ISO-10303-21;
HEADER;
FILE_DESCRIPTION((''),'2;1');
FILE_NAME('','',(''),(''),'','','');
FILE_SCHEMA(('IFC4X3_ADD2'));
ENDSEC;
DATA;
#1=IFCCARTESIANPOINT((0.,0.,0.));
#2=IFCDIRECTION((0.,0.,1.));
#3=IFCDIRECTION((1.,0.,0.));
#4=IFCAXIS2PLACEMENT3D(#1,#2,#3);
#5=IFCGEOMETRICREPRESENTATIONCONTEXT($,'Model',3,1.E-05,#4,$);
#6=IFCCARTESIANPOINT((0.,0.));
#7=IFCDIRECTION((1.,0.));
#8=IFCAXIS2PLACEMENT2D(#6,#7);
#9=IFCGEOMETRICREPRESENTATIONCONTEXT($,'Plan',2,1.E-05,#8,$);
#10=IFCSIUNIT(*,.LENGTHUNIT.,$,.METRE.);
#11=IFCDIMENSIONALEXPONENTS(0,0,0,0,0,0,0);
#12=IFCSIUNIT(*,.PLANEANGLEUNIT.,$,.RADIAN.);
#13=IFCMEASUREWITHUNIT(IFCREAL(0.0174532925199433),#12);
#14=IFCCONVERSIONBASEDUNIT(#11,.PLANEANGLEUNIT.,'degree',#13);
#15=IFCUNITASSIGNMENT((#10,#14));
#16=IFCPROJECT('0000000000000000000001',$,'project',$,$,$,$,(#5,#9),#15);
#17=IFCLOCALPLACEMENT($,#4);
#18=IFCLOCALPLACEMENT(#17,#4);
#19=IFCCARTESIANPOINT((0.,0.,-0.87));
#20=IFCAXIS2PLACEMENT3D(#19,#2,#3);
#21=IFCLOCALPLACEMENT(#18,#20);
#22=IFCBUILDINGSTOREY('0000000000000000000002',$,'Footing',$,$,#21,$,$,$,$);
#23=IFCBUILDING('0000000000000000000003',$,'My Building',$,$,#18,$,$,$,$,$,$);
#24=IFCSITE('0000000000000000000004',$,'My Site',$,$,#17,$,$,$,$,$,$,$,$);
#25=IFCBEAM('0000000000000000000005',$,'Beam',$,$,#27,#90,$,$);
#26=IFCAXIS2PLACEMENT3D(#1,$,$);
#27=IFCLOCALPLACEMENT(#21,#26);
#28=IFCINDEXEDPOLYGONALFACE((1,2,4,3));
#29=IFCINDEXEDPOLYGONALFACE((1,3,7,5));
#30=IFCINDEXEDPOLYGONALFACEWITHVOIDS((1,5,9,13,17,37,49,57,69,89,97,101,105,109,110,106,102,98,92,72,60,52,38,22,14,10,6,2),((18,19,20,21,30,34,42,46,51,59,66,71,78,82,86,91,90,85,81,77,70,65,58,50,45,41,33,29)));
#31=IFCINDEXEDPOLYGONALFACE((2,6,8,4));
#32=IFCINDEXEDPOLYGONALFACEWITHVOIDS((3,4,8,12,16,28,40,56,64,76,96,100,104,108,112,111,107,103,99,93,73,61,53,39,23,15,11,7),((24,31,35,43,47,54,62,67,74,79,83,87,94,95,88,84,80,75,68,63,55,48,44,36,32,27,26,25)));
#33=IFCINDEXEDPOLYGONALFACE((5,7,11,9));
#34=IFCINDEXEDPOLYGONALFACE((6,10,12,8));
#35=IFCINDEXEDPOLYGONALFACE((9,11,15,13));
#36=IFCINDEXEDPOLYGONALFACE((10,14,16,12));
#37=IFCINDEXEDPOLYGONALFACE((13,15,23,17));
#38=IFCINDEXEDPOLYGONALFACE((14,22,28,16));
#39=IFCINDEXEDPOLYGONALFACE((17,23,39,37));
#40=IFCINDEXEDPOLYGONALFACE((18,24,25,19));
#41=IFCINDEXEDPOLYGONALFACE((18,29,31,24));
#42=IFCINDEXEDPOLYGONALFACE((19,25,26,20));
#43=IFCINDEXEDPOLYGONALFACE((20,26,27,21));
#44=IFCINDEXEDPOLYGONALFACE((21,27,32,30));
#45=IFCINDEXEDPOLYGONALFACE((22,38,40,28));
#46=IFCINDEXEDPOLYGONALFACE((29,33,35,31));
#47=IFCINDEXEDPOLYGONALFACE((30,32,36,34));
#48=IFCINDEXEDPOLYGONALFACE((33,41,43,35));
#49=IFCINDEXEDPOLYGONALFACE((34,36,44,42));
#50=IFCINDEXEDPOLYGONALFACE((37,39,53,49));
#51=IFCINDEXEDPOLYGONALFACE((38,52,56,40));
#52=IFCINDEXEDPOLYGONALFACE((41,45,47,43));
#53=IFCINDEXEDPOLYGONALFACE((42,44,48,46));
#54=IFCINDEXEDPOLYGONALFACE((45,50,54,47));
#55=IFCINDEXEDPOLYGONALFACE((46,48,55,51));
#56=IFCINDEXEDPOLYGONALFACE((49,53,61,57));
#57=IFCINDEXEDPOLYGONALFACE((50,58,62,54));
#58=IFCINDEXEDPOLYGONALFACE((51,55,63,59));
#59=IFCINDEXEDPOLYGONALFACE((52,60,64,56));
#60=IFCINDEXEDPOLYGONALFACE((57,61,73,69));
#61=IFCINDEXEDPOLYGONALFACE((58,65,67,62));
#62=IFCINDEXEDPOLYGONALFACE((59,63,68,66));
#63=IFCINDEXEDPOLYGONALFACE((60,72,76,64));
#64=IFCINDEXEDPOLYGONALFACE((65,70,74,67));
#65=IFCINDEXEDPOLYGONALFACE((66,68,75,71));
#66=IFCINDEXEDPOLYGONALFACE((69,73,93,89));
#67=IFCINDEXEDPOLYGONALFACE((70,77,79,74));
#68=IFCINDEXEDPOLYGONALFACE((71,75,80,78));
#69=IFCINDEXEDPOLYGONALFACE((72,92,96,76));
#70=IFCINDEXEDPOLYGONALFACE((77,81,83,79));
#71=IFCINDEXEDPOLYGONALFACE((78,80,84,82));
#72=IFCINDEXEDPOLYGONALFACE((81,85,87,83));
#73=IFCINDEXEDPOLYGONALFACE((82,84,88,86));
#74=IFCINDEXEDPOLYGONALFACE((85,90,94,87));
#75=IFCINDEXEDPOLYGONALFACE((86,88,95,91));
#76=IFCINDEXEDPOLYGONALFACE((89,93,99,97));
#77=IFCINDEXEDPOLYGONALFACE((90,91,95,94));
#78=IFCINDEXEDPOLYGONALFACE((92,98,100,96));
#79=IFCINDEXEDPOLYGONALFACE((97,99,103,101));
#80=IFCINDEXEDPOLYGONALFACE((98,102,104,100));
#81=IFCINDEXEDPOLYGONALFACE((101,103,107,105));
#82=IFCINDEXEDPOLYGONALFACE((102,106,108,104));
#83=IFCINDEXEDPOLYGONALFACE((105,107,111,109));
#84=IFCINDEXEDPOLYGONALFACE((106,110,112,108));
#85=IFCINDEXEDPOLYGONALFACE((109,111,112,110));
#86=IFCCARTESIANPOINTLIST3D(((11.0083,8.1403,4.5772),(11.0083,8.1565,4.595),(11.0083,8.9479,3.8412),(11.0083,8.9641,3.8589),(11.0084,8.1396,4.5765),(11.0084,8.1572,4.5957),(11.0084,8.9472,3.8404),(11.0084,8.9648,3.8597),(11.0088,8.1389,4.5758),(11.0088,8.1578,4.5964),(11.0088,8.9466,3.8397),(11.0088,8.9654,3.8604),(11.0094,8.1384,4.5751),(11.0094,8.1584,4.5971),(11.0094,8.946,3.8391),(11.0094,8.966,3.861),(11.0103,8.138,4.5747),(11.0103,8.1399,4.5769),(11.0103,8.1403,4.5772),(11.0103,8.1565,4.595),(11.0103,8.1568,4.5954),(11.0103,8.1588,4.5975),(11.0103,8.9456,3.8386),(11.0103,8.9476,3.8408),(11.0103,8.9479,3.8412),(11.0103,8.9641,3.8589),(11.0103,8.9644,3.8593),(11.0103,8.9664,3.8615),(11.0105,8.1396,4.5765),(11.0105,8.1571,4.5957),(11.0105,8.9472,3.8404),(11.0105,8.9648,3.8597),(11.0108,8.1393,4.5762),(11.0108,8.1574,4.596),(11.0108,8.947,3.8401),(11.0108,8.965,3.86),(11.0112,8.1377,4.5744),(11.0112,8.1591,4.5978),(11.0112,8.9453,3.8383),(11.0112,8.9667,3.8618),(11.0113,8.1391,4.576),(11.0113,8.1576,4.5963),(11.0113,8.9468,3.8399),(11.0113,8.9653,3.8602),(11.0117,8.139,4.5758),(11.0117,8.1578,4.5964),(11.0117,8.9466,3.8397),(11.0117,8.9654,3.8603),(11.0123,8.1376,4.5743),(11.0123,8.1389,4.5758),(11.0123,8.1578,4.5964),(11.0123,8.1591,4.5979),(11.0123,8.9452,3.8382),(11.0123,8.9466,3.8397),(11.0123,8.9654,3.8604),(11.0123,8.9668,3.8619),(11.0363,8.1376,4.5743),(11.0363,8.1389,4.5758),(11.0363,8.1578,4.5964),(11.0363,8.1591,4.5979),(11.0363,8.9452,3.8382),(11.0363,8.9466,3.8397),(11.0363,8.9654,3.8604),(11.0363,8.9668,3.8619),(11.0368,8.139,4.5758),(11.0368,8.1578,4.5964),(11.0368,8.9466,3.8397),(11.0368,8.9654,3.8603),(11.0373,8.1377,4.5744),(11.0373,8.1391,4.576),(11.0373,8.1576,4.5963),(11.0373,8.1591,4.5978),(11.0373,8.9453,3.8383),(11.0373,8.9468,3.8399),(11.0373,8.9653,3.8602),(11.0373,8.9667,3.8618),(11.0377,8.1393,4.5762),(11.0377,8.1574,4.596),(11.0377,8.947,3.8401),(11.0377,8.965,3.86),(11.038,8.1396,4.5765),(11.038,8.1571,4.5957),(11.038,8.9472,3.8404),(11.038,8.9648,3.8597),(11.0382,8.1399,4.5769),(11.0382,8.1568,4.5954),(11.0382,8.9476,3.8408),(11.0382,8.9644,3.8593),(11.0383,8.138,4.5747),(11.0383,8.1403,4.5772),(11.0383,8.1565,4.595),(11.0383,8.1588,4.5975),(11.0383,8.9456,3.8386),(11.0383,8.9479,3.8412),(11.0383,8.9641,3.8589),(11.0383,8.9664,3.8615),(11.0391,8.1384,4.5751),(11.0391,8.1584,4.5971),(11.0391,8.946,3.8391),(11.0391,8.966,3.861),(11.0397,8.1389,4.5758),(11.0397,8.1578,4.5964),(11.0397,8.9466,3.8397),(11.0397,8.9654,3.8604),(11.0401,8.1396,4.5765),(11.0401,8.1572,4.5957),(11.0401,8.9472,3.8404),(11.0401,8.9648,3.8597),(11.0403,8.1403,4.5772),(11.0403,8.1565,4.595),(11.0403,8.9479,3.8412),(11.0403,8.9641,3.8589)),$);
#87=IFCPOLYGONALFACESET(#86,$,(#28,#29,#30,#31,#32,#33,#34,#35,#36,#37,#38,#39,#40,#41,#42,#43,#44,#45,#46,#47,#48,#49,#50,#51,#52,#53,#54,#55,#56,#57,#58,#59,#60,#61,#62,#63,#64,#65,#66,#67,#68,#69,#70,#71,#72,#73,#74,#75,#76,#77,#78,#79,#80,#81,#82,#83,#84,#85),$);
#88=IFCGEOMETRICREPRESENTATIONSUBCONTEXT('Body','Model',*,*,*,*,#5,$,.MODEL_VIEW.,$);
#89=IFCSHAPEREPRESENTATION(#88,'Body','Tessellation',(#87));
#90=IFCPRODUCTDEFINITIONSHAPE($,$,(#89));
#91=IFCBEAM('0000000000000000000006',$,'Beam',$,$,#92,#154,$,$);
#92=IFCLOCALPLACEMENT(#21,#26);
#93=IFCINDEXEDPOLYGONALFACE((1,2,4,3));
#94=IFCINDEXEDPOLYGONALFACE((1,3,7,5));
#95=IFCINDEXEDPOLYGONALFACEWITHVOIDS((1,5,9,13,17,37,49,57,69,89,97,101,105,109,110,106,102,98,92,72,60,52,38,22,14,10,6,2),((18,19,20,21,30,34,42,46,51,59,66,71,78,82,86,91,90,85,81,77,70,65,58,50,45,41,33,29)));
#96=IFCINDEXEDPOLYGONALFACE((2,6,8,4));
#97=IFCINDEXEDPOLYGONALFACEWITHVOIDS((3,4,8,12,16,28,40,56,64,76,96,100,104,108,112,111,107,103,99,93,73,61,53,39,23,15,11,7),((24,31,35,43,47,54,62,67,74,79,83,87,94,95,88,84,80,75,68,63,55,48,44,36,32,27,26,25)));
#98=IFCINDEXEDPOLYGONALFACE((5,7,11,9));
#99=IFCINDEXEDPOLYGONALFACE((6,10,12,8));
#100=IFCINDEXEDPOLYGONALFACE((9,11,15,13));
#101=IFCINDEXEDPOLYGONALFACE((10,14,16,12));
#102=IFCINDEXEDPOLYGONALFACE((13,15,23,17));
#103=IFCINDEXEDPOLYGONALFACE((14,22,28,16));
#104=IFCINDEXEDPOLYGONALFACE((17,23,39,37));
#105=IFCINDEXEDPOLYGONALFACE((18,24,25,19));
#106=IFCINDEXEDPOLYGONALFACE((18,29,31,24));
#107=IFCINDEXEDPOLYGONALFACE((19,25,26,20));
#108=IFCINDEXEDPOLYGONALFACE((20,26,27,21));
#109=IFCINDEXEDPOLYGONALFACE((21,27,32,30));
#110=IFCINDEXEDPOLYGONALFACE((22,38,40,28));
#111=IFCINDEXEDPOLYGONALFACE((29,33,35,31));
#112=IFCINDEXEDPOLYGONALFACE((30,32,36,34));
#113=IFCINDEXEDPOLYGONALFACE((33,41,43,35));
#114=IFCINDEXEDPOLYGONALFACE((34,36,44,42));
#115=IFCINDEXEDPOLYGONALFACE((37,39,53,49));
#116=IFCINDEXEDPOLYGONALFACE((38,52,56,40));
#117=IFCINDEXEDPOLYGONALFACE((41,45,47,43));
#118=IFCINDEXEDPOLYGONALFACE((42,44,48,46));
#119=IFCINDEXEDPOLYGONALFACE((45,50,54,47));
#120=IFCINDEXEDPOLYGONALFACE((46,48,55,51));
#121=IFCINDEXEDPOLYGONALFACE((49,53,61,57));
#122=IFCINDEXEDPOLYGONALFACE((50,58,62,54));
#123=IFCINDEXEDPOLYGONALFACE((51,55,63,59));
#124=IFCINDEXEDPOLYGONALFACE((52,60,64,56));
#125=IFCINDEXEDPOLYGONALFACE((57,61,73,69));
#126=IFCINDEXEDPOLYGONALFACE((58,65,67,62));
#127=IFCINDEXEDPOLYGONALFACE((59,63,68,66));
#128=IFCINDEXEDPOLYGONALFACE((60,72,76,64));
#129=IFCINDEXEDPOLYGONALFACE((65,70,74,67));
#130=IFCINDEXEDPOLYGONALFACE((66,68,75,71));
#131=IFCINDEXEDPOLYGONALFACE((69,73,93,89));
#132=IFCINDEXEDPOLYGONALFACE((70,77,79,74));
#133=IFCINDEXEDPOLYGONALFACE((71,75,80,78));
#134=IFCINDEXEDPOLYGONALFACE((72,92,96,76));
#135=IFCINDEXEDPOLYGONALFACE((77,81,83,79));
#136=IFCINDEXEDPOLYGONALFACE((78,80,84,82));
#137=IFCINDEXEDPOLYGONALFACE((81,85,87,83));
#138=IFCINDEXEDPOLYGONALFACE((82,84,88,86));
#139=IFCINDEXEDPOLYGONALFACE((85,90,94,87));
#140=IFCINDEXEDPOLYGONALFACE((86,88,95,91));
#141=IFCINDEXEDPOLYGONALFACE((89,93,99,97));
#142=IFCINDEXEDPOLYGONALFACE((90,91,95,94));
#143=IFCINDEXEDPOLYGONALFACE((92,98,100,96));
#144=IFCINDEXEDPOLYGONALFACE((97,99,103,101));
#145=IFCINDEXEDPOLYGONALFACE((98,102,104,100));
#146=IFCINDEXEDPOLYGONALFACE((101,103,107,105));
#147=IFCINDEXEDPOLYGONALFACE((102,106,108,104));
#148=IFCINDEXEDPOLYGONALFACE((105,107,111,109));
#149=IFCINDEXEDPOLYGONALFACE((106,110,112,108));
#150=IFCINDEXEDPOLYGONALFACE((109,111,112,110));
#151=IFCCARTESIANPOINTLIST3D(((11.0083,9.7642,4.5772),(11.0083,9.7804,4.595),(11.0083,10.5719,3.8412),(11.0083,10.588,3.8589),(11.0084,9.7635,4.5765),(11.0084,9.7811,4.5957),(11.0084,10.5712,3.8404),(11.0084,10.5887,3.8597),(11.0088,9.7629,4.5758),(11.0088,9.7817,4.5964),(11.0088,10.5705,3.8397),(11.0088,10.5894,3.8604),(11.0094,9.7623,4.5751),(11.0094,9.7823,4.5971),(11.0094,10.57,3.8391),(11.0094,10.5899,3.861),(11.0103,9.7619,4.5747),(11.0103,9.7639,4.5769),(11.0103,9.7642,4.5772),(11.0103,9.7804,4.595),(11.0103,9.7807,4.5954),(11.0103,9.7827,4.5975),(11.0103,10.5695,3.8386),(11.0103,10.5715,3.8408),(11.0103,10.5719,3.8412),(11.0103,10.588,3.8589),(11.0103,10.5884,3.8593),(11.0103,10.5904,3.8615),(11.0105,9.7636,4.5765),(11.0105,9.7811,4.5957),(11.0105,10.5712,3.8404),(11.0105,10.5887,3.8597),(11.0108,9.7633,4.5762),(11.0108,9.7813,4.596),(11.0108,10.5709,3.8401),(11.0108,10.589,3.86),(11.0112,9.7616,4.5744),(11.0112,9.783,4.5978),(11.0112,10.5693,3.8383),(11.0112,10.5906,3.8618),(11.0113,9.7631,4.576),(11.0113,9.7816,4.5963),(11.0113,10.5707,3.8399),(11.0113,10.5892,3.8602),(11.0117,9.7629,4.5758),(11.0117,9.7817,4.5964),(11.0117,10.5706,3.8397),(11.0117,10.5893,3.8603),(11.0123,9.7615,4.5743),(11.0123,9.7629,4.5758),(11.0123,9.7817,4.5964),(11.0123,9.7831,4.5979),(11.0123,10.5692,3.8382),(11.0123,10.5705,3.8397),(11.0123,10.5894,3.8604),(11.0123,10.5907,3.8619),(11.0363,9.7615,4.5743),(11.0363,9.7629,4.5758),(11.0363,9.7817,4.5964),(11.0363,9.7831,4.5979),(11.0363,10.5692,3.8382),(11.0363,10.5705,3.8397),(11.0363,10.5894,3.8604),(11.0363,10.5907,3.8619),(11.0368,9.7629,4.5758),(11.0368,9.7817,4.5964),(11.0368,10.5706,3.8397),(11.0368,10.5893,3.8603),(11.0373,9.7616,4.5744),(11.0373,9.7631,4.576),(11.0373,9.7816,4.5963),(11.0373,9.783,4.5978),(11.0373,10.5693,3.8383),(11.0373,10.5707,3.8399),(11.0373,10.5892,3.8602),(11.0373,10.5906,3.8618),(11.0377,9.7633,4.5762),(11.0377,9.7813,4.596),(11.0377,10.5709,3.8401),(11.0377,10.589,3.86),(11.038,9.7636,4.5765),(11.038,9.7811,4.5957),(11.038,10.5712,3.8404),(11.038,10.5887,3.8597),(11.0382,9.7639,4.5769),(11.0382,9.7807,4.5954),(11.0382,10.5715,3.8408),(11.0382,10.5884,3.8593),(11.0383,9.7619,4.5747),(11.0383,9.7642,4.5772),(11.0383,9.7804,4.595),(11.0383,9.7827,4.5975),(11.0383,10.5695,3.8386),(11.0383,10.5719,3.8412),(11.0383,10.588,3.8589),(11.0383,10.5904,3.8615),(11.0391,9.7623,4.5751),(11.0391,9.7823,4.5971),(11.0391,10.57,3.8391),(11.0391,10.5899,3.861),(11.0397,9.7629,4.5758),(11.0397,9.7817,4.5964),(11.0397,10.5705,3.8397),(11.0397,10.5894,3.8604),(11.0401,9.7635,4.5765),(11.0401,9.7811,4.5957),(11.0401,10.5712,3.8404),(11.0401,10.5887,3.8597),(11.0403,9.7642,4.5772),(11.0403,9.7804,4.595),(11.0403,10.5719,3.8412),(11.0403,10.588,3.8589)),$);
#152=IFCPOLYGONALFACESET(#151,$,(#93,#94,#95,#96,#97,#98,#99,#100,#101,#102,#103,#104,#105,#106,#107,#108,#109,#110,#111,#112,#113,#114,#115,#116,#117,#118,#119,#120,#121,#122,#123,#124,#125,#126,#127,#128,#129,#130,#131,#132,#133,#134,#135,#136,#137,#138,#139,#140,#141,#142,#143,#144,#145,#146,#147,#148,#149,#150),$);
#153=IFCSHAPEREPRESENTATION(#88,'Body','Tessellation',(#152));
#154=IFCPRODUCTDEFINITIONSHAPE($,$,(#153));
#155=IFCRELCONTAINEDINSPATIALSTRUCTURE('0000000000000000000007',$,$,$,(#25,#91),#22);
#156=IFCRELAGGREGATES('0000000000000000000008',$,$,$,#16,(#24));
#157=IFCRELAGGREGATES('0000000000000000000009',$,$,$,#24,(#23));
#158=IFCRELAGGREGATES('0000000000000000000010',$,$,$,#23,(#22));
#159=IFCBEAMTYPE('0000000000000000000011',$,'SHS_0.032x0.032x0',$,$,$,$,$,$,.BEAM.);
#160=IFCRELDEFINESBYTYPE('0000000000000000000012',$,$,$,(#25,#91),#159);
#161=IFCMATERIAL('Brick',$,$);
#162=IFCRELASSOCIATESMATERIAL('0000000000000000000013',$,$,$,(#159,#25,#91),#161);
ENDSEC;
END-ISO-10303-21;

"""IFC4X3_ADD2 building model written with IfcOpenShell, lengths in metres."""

from ifc_helpers import new_model, entity, si_unit, converted_unit, frame, origin_with_axes, origin_2d_with_axis, place, context, subcontext, project, spatial, hollow_rectangle, extrude, material, material_profile, profile_set, profile_usage, type_object, element, save


model = new_model("IFC4X3_ADD2")

# Units and contexts
model_context = context("Model", 3, precision=1e-05, world=origin_with_axes())
plan_context = context("Plan", 2, precision=1e-05, world=origin_2d_with_axis())
body_context = subcontext(model_context, "Body", "Model", "MODEL_VIEW")
ifc_project = project(units=[si_unit("LENGTHUNIT", "METRE"), converted_unit("PLANEANGLEUNIT", "degree", entity("IfcReal", 0.0174532925199433), si_unit("PLANEANGLEUNIT", "RADIAN"), dimensions=[0, 0, 0, 0, 0, 0, 0])], contexts=[model_context, plan_context])

# Site, building, storey
site_placement = place(None, origin_with_axes())
site = spatial("IfcSite", under=ifc_project, at=site_placement, Name="My Site")
building_placement = place(site_placement, origin_with_axes())
building = spatial("IfcBuilding", under=site, at=building_placement, Name="My Building")
storey_placement = place(building_placement, frame((0.0, 0.0, -0.87), z_axis=(0.0, 0.0, 1.0), x_axis=(1.0, 0.0, 0.0)))
storey = spatial("IfcBuildingStorey", under=building, at=storey_placement, Name="Footing")

# Beams
ifc_material_1 = material(Name="Brick")
ifc_material_profile = material_profile(ifc_material_1, hollow_rectangle(XDim=0.032, YDim=0.032, WallThickness=0.002, InnerFilletRadius=0.002, OuterFilletRadius=0.004))
ifc_profile_set = profile_set([ifc_material_profile])
beam_type_1 = type_object("IfcBeamType", Name="SHS_0.032x0.032x0", PredefinedType="BEAM", material=ifc_profile_set)
ifc_profile_usage_1 = profile_usage(ifc_profile_set, cardinal=5)
beam_1_placement = place(storey_placement, frame((11.0243, 8.1484, 4.5861), z_axis=(0.0, 0.739099, -0.673597), x_axis=(-1.0, 0.0, 0.0)))
element("IfcBeam", 1, at=beam_1_placement, inside=storey, type_object=beam_type_1, material=ifc_profile_usage_1, Name="Beam", context=body_context, shape_type="SweptSolid", body=[
    extrude(hollow_rectangle(XDim=0.032, YDim=0.032, WallThickness=0.002, InnerFilletRadius=0.002, OuterFilletRadius=0.004), origin_with_axes(), (0.0, 0.0, 1.0), 1.0927),
])
ifc_profile_usage_2 = profile_usage(ifc_profile_set, cardinal=5)
beam_2_placement = place(storey_placement, frame((11.0243, 9.7723, 4.5861), z_axis=(0.0, 0.739099, -0.673597), x_axis=(-1.0, 0.0, 0.0)))
element("IfcBeam", 2, at=beam_2_placement, inside=storey, type_object=beam_type_1, material=ifc_profile_usage_2, Name="Beam", context=body_context, shape_type="SweptSolid", body=[
    extrude(hollow_rectangle(XDim=0.032, YDim=0.032, WallThickness=0.002, InnerFilletRadius=0.002, OuterFilletRadius=0.004), origin_with_axes(), (0.0, 0.0, 1.0), 1.0927),
])

save(model, "model.ifc")
